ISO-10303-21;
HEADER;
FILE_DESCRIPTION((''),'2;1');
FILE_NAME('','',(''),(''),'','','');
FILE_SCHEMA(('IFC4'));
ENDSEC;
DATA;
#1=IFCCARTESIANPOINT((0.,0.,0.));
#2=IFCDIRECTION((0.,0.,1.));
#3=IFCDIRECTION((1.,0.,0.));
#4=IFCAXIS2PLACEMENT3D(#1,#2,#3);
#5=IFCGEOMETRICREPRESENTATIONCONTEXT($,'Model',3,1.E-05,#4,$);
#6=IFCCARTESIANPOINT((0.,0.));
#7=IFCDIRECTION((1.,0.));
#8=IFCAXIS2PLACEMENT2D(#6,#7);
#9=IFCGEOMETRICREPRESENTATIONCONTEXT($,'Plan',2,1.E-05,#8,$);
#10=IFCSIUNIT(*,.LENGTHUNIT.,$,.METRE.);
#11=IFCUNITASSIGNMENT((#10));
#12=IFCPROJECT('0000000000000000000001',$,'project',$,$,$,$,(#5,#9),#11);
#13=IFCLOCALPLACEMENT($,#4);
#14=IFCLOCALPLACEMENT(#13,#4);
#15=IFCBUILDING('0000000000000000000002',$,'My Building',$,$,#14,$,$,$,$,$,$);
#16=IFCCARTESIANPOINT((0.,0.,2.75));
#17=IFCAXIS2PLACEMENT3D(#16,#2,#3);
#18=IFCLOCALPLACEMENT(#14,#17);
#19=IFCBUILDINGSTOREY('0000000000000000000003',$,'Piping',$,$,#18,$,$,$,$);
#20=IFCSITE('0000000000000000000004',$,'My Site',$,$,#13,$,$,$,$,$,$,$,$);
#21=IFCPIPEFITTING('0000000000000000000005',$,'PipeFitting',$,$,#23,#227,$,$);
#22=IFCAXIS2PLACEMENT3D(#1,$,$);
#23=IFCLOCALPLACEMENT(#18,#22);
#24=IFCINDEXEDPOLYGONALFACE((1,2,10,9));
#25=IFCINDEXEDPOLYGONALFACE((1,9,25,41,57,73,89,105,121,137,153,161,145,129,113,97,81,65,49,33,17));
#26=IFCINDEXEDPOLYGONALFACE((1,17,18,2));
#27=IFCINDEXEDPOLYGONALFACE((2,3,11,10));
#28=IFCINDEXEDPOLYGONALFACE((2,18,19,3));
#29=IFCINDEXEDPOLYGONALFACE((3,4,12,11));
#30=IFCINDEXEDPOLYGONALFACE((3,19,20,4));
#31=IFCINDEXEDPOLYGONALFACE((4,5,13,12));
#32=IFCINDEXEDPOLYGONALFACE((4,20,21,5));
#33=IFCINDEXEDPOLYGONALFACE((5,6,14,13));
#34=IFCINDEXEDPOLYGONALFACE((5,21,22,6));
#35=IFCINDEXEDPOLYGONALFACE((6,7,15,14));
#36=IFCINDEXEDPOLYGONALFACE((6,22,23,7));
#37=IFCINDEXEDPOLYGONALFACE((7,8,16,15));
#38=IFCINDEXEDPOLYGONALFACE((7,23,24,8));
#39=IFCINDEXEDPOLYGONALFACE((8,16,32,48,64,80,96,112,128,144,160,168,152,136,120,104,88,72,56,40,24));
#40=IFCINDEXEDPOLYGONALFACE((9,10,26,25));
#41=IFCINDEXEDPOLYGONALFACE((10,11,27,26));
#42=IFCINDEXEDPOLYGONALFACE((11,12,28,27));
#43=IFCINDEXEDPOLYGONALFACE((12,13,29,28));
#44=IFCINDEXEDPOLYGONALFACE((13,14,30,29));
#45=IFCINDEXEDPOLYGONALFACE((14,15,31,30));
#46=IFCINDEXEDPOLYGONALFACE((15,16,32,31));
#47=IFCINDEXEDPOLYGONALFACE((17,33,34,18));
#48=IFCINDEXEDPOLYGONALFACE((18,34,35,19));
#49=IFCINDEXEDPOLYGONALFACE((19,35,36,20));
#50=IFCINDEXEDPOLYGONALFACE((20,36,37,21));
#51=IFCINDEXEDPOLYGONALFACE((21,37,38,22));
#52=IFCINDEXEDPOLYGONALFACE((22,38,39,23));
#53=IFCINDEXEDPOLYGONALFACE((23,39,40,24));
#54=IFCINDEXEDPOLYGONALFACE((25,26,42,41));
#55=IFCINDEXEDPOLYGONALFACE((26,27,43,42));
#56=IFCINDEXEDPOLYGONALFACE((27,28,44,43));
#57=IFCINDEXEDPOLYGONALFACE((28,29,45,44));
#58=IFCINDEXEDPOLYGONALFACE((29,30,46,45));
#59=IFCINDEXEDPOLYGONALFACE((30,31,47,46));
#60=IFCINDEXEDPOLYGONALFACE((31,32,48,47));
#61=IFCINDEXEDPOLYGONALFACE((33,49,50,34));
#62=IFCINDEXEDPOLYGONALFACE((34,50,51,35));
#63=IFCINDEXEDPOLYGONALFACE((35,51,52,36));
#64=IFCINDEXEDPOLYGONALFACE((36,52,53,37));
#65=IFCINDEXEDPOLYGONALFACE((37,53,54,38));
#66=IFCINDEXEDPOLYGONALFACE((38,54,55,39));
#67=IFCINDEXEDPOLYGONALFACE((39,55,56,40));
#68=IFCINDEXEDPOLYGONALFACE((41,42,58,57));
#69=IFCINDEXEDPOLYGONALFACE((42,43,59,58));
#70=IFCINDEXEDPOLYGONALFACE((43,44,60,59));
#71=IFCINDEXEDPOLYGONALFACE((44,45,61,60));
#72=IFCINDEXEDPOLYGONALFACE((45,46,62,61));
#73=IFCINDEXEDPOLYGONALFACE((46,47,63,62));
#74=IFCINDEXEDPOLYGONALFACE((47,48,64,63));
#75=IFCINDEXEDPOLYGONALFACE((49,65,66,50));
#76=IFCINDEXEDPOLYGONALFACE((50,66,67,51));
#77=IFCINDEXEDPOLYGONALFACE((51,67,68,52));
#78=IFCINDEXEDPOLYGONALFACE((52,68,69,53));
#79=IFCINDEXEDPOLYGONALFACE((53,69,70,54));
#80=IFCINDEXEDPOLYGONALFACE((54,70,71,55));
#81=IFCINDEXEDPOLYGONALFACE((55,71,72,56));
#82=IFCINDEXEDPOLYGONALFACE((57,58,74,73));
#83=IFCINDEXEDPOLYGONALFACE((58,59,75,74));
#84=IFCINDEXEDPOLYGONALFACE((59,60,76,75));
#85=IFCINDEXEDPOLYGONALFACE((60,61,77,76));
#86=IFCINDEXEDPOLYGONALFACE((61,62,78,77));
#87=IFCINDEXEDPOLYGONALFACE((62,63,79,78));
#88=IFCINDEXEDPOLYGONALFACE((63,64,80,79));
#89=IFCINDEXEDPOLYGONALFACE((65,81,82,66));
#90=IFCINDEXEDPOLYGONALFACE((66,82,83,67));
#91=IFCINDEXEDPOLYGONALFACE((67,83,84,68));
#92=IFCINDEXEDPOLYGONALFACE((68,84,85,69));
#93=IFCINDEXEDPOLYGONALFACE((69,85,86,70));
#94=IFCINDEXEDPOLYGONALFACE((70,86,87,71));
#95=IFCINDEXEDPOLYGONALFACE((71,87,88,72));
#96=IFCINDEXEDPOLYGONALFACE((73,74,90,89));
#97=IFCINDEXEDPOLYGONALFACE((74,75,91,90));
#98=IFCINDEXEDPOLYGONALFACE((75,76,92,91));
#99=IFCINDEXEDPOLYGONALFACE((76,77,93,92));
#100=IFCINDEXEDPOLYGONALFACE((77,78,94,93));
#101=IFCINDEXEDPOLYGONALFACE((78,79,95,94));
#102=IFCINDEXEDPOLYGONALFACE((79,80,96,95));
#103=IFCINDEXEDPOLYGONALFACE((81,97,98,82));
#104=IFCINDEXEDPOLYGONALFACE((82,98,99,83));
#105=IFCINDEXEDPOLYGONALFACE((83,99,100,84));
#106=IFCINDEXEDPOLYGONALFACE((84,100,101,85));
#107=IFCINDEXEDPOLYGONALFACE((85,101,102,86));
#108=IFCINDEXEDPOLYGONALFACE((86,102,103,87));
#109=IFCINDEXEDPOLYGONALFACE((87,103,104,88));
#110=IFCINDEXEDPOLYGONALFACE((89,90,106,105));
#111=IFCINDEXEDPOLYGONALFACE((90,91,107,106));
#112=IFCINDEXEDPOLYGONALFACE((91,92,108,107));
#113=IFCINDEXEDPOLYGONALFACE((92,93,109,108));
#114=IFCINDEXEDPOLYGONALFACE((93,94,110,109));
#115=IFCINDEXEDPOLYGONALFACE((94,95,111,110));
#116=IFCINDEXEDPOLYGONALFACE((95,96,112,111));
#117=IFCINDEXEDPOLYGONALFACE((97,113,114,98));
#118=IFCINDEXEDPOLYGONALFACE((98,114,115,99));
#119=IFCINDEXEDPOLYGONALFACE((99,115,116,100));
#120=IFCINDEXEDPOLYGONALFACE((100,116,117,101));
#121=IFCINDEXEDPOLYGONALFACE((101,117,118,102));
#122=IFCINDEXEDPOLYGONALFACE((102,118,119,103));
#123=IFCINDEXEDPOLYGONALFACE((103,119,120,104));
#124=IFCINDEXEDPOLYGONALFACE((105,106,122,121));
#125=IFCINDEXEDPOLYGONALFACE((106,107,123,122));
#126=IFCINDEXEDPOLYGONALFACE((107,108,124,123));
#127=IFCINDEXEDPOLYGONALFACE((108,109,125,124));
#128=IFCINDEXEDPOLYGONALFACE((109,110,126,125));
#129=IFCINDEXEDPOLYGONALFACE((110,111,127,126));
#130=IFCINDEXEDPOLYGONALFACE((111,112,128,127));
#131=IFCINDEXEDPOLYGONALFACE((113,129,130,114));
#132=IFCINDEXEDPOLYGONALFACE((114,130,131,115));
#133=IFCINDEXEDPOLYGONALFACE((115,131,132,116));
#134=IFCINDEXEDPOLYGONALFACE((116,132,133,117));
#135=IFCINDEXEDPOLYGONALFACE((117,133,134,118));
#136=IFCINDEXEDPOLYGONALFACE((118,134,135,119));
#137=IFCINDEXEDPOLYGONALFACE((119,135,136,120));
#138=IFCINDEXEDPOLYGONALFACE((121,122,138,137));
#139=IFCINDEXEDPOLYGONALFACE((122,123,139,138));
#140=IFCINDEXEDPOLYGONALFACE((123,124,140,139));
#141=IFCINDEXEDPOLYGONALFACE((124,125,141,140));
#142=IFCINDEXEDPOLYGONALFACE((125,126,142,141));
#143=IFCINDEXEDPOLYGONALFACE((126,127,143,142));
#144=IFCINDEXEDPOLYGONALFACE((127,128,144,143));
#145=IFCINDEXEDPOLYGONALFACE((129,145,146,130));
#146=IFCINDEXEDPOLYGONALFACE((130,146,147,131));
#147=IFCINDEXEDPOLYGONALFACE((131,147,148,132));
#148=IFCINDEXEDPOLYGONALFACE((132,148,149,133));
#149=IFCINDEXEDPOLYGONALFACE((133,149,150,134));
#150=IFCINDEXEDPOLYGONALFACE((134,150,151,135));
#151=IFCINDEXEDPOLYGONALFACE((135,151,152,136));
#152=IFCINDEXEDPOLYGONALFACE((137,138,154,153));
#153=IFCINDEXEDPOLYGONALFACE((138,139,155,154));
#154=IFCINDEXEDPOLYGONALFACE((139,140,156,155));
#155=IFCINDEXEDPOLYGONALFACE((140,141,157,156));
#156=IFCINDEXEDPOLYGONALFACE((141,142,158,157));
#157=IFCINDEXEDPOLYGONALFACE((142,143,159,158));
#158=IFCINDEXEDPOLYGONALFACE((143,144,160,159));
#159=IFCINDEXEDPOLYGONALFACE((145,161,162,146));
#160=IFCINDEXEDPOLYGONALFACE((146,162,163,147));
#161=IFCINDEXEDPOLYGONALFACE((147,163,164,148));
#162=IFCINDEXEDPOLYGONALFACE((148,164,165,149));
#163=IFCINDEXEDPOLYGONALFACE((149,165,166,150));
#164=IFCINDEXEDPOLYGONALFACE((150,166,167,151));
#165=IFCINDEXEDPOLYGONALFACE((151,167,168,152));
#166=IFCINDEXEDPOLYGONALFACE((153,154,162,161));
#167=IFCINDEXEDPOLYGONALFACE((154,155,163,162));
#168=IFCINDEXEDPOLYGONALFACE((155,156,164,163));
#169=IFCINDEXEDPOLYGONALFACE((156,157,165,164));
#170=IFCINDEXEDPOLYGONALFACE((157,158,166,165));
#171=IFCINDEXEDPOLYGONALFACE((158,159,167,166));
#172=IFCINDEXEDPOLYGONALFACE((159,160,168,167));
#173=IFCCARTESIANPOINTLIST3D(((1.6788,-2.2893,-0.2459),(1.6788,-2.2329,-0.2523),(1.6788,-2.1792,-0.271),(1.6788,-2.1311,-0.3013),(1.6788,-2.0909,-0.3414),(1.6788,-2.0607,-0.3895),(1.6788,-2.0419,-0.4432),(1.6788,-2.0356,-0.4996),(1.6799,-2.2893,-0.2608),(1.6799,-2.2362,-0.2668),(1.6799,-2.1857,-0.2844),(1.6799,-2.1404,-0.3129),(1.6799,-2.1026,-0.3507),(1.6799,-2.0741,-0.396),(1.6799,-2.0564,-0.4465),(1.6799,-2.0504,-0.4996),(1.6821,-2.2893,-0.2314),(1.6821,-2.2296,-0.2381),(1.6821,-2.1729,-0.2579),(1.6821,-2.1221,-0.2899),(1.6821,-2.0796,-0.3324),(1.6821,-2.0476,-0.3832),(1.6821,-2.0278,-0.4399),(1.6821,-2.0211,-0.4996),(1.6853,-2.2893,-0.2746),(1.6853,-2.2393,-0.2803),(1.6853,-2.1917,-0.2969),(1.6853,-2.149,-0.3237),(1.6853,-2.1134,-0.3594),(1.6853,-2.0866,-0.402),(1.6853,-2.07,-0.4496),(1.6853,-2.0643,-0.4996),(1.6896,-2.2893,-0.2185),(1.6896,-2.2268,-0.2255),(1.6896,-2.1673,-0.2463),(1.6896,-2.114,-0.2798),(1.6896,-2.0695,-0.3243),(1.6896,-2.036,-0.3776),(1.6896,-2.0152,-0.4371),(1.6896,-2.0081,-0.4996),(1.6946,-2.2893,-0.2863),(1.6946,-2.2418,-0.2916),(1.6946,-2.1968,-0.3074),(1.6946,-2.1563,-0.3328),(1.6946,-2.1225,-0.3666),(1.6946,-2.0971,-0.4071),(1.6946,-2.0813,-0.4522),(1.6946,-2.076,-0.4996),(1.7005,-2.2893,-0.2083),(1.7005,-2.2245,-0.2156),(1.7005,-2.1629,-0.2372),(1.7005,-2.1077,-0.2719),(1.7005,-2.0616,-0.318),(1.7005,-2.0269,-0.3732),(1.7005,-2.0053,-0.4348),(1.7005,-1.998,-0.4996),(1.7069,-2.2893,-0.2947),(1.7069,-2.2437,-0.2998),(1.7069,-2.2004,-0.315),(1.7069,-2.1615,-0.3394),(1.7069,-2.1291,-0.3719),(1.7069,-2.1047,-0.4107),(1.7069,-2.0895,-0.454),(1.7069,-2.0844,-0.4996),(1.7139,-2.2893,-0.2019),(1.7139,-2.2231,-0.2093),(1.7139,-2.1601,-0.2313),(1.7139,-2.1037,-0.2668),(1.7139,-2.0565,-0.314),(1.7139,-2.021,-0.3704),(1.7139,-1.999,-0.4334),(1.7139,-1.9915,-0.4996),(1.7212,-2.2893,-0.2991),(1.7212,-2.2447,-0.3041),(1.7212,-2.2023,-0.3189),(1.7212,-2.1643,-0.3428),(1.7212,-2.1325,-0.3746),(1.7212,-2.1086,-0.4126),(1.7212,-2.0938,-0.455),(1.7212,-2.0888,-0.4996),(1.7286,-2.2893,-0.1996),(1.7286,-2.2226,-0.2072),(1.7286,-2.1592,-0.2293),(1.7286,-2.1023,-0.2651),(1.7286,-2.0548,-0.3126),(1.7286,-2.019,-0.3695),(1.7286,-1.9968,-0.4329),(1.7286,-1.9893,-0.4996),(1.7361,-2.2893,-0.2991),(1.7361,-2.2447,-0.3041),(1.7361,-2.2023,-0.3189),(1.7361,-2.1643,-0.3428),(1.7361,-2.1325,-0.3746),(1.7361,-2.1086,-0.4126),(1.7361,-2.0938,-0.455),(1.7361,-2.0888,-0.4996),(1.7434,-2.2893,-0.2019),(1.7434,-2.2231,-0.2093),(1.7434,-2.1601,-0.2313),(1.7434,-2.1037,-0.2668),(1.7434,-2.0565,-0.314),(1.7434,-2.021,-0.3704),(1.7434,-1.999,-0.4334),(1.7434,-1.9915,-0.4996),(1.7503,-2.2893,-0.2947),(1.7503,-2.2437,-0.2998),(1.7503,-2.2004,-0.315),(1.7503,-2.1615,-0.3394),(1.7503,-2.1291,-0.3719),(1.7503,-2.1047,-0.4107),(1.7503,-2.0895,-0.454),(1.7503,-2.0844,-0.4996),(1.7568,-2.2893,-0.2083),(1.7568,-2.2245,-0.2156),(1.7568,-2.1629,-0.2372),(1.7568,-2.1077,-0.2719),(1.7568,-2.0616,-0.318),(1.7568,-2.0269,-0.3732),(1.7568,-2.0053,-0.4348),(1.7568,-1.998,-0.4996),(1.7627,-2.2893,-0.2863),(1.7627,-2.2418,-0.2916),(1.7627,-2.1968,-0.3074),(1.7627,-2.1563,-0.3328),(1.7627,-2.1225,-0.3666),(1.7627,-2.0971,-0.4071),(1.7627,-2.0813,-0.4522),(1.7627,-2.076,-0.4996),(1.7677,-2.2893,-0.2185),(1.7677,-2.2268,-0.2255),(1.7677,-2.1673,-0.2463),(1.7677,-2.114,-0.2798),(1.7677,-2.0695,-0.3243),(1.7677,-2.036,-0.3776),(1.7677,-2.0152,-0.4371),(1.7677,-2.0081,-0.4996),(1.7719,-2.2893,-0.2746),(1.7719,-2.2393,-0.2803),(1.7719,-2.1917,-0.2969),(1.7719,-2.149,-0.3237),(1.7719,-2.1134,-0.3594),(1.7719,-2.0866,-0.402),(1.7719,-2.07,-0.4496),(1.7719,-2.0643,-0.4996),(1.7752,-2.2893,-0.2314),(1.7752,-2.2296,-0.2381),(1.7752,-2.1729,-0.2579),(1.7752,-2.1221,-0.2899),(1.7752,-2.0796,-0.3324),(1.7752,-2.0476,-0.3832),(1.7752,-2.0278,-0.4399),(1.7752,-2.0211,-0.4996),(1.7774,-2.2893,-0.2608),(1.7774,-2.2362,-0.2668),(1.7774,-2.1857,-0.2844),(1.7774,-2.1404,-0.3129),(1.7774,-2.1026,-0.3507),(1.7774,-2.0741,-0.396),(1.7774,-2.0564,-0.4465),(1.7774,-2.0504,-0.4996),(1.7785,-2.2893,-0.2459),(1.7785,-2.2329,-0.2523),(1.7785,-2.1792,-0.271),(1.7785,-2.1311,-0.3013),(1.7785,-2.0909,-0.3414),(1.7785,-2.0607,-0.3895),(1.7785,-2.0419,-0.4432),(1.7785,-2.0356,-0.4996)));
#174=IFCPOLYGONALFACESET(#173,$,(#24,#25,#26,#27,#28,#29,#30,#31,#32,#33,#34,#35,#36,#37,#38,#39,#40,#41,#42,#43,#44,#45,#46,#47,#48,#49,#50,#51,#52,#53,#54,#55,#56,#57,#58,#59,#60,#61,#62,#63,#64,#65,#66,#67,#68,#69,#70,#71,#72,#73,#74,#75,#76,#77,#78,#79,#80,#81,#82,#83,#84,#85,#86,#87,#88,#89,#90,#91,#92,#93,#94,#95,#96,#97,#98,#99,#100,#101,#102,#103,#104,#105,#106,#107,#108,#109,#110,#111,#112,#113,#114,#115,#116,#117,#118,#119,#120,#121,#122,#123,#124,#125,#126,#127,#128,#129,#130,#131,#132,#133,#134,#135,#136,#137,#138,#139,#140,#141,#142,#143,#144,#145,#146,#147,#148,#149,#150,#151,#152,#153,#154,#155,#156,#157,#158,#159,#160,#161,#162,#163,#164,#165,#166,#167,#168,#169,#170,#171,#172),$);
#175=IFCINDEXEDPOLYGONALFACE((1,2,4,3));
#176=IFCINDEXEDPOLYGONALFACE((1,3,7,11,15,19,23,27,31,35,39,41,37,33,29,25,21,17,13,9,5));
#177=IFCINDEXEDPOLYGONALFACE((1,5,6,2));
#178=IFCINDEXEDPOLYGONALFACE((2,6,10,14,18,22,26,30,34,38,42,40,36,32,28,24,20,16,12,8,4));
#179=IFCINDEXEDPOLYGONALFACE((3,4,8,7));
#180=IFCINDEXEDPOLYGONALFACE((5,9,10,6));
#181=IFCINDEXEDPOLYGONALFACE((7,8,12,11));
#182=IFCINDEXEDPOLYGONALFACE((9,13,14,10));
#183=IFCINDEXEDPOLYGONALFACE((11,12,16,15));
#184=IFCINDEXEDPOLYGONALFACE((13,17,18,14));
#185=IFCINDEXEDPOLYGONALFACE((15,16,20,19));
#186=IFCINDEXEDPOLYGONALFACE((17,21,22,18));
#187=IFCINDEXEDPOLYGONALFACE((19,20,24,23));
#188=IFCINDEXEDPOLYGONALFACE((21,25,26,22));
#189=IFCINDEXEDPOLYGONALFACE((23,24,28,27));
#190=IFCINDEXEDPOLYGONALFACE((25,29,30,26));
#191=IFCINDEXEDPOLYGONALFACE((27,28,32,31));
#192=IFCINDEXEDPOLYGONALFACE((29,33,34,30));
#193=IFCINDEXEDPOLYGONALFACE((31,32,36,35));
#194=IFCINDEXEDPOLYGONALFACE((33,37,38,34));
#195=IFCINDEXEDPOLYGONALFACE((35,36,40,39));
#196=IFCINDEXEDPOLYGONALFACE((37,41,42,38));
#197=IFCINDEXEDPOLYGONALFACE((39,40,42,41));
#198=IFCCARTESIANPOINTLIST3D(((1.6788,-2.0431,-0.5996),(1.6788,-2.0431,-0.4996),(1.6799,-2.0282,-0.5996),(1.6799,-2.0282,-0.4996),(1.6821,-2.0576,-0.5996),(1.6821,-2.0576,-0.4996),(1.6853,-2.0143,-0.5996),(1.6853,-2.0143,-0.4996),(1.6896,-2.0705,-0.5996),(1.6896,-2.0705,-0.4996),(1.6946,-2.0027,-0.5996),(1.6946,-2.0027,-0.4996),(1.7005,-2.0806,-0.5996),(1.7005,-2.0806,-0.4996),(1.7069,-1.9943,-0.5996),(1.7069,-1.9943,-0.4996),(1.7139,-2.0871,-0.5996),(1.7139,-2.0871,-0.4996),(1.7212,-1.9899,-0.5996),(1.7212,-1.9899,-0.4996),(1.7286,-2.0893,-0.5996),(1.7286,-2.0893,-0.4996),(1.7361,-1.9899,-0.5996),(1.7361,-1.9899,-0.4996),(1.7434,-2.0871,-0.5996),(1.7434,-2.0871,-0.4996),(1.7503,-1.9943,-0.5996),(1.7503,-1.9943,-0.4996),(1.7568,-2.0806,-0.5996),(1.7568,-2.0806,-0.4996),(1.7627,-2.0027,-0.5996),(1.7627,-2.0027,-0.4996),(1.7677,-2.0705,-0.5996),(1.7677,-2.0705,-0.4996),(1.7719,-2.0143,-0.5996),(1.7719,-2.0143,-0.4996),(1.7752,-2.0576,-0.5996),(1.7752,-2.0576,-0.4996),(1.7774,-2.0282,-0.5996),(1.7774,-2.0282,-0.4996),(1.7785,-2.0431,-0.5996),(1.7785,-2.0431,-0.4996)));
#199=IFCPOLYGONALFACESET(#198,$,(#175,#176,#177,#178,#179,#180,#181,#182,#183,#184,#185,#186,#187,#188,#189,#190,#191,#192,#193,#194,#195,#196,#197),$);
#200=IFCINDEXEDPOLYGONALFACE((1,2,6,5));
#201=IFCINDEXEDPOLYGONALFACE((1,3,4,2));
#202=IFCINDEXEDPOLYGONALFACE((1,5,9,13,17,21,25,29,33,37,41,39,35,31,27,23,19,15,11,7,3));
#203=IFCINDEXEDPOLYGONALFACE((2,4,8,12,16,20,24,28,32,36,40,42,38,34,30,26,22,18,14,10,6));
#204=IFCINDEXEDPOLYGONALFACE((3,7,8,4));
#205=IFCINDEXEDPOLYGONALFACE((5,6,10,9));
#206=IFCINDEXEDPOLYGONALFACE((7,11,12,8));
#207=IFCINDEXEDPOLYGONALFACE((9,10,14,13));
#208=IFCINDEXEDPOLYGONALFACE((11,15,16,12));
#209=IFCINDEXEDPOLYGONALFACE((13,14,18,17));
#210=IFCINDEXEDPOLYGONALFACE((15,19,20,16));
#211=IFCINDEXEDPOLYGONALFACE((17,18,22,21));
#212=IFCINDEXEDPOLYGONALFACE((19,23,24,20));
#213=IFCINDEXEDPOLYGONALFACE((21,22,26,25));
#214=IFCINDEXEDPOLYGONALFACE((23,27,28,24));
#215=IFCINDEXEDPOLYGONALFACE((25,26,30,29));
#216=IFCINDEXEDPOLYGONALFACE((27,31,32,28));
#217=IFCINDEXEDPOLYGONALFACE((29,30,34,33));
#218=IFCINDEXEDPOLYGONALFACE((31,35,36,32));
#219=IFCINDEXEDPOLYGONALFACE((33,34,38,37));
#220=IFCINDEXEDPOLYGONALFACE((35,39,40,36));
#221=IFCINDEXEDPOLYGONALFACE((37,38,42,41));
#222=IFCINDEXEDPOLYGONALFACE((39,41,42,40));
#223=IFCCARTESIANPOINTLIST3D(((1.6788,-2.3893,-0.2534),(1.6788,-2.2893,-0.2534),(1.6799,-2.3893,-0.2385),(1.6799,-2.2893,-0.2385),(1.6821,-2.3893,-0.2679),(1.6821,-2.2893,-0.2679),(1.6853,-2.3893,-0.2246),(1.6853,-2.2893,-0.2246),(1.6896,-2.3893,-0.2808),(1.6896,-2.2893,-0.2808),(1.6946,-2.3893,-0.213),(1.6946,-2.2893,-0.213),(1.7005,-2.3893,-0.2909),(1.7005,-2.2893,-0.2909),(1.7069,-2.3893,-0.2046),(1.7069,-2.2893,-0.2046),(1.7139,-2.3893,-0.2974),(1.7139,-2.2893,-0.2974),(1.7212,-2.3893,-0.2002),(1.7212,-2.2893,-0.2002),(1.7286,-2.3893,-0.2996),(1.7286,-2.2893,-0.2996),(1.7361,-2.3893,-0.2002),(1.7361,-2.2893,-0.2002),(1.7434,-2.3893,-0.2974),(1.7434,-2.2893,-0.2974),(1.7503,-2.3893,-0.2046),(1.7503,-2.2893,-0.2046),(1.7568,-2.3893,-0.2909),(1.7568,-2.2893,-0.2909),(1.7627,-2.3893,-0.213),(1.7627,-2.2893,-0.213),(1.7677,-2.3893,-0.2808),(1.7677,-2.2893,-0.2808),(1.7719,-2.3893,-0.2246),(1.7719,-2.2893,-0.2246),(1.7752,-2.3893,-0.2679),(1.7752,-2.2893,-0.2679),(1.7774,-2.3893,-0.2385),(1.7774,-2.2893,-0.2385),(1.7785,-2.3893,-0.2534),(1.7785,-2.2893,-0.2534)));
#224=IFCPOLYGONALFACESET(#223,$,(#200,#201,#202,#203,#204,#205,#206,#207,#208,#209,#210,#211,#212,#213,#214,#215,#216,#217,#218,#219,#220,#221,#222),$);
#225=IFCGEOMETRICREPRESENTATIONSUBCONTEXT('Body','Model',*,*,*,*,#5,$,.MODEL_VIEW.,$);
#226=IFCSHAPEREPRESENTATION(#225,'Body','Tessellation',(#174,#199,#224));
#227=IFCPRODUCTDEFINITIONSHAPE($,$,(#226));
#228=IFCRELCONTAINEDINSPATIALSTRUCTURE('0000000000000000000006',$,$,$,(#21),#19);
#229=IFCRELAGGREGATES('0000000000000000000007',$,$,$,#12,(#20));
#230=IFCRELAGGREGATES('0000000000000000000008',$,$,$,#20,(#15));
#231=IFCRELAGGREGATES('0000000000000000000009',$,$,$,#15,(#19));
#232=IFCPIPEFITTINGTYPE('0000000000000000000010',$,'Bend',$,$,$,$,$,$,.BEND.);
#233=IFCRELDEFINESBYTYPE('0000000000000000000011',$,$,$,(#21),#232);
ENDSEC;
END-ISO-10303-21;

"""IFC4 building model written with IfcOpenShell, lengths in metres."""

from ifc_helpers import new_model, entity, si_unit, frame, origin_with_axes, origin_2d_with_axis, place, context, subcontext, project, spatial, circle, extrude, source, transform, mapped, type_object, type_shapes, element, save


model = new_model("IFC4")

# Units and contexts
model_context = context("Model", 3, precision=1e-05, world=origin_with_axes())
plan_context = context("Plan", 2, precision=1e-05, world=origin_2d_with_axis())
body_context = subcontext(model_context, "Body", "Model", "MODEL_VIEW")
ifc_project = project(units=[si_unit("LENGTHUNIT", "METRE")], contexts=[model_context, plan_context])

# Site, building, storey
site_placement = place(None, origin_with_axes())
site = spatial("IfcSite", under=ifc_project, at=site_placement, Name="My Site")
building_placement = place(site_placement, origin_with_axes())
building = spatial("IfcBuilding", under=site, at=building_placement, Name="My Building")
storey_placement = place(building_placement, frame((0.0, 0.0, 2.75), z_axis=(0.0, 0.0, 1.0), x_axis=(1.0, 0.0, 0.0)))
storey = spatial("IfcBuildingStorey", under=building, at=storey_placement, Name="Piping")

# Pipe fitting
pipe_fitting_type = type_object("IfcPipeFittingType", Name="Bend", PredefinedType="BEND")
shared_shape = source(origin_with_axes(), body_context, "Body", "SolidModel", [
    entity("IfcSweptDiskSolid", entity("IfcIndexedPolyCurve", entity("IfcCartesianPointList3D", [[0.0, 0.0, -0.1], [0.0732, 0.0, -0.2768], [0.25, 0.0, -0.35]]), [entity("IfcArcIndex", [1, 2, 3])]), 0.05),
    extrude(circle(Radius=0.05), origin_with_axes(), (0.0, 0.0, -1.0), 0.1),
    extrude(circle(Radius=0.05), frame((0.25, 0.0, -0.35), z_axis=(1.0, 0.0, 0.0), x_axis=(0.0, 0.0, 1.0)), (0.0, 0.0, 1.0), 0.1),
])
type_shapes(pipe_fitting_type, [shared_shape])
for number, where, z_axis, x_axis, name in (
    (1, (1.7286, -2.0393, -0.5996), (0.0, 0.0, -1.0), (0.0, -1.0, 0.0), "PipeFitting"),
):
    element("IfcPipeFitting", number, at=place(storey_placement, frame(where, z_axis=z_axis, x_axis=x_axis)), inside=storey, type_object=pipe_fitting_type, Name=name, context=body_context, shape_type="MappedRepresentation", body=[
        mapped(shared_shape, transform((0.0, 0.0, 0.0), x_axis=(1.0, 0.0, 0.0), y_axis=(0.0, 1.0, 0.0), z_axis=(0.0, 0.0, 1.0), scale=1.0)),
    ])

save(model, "model.ifc")
